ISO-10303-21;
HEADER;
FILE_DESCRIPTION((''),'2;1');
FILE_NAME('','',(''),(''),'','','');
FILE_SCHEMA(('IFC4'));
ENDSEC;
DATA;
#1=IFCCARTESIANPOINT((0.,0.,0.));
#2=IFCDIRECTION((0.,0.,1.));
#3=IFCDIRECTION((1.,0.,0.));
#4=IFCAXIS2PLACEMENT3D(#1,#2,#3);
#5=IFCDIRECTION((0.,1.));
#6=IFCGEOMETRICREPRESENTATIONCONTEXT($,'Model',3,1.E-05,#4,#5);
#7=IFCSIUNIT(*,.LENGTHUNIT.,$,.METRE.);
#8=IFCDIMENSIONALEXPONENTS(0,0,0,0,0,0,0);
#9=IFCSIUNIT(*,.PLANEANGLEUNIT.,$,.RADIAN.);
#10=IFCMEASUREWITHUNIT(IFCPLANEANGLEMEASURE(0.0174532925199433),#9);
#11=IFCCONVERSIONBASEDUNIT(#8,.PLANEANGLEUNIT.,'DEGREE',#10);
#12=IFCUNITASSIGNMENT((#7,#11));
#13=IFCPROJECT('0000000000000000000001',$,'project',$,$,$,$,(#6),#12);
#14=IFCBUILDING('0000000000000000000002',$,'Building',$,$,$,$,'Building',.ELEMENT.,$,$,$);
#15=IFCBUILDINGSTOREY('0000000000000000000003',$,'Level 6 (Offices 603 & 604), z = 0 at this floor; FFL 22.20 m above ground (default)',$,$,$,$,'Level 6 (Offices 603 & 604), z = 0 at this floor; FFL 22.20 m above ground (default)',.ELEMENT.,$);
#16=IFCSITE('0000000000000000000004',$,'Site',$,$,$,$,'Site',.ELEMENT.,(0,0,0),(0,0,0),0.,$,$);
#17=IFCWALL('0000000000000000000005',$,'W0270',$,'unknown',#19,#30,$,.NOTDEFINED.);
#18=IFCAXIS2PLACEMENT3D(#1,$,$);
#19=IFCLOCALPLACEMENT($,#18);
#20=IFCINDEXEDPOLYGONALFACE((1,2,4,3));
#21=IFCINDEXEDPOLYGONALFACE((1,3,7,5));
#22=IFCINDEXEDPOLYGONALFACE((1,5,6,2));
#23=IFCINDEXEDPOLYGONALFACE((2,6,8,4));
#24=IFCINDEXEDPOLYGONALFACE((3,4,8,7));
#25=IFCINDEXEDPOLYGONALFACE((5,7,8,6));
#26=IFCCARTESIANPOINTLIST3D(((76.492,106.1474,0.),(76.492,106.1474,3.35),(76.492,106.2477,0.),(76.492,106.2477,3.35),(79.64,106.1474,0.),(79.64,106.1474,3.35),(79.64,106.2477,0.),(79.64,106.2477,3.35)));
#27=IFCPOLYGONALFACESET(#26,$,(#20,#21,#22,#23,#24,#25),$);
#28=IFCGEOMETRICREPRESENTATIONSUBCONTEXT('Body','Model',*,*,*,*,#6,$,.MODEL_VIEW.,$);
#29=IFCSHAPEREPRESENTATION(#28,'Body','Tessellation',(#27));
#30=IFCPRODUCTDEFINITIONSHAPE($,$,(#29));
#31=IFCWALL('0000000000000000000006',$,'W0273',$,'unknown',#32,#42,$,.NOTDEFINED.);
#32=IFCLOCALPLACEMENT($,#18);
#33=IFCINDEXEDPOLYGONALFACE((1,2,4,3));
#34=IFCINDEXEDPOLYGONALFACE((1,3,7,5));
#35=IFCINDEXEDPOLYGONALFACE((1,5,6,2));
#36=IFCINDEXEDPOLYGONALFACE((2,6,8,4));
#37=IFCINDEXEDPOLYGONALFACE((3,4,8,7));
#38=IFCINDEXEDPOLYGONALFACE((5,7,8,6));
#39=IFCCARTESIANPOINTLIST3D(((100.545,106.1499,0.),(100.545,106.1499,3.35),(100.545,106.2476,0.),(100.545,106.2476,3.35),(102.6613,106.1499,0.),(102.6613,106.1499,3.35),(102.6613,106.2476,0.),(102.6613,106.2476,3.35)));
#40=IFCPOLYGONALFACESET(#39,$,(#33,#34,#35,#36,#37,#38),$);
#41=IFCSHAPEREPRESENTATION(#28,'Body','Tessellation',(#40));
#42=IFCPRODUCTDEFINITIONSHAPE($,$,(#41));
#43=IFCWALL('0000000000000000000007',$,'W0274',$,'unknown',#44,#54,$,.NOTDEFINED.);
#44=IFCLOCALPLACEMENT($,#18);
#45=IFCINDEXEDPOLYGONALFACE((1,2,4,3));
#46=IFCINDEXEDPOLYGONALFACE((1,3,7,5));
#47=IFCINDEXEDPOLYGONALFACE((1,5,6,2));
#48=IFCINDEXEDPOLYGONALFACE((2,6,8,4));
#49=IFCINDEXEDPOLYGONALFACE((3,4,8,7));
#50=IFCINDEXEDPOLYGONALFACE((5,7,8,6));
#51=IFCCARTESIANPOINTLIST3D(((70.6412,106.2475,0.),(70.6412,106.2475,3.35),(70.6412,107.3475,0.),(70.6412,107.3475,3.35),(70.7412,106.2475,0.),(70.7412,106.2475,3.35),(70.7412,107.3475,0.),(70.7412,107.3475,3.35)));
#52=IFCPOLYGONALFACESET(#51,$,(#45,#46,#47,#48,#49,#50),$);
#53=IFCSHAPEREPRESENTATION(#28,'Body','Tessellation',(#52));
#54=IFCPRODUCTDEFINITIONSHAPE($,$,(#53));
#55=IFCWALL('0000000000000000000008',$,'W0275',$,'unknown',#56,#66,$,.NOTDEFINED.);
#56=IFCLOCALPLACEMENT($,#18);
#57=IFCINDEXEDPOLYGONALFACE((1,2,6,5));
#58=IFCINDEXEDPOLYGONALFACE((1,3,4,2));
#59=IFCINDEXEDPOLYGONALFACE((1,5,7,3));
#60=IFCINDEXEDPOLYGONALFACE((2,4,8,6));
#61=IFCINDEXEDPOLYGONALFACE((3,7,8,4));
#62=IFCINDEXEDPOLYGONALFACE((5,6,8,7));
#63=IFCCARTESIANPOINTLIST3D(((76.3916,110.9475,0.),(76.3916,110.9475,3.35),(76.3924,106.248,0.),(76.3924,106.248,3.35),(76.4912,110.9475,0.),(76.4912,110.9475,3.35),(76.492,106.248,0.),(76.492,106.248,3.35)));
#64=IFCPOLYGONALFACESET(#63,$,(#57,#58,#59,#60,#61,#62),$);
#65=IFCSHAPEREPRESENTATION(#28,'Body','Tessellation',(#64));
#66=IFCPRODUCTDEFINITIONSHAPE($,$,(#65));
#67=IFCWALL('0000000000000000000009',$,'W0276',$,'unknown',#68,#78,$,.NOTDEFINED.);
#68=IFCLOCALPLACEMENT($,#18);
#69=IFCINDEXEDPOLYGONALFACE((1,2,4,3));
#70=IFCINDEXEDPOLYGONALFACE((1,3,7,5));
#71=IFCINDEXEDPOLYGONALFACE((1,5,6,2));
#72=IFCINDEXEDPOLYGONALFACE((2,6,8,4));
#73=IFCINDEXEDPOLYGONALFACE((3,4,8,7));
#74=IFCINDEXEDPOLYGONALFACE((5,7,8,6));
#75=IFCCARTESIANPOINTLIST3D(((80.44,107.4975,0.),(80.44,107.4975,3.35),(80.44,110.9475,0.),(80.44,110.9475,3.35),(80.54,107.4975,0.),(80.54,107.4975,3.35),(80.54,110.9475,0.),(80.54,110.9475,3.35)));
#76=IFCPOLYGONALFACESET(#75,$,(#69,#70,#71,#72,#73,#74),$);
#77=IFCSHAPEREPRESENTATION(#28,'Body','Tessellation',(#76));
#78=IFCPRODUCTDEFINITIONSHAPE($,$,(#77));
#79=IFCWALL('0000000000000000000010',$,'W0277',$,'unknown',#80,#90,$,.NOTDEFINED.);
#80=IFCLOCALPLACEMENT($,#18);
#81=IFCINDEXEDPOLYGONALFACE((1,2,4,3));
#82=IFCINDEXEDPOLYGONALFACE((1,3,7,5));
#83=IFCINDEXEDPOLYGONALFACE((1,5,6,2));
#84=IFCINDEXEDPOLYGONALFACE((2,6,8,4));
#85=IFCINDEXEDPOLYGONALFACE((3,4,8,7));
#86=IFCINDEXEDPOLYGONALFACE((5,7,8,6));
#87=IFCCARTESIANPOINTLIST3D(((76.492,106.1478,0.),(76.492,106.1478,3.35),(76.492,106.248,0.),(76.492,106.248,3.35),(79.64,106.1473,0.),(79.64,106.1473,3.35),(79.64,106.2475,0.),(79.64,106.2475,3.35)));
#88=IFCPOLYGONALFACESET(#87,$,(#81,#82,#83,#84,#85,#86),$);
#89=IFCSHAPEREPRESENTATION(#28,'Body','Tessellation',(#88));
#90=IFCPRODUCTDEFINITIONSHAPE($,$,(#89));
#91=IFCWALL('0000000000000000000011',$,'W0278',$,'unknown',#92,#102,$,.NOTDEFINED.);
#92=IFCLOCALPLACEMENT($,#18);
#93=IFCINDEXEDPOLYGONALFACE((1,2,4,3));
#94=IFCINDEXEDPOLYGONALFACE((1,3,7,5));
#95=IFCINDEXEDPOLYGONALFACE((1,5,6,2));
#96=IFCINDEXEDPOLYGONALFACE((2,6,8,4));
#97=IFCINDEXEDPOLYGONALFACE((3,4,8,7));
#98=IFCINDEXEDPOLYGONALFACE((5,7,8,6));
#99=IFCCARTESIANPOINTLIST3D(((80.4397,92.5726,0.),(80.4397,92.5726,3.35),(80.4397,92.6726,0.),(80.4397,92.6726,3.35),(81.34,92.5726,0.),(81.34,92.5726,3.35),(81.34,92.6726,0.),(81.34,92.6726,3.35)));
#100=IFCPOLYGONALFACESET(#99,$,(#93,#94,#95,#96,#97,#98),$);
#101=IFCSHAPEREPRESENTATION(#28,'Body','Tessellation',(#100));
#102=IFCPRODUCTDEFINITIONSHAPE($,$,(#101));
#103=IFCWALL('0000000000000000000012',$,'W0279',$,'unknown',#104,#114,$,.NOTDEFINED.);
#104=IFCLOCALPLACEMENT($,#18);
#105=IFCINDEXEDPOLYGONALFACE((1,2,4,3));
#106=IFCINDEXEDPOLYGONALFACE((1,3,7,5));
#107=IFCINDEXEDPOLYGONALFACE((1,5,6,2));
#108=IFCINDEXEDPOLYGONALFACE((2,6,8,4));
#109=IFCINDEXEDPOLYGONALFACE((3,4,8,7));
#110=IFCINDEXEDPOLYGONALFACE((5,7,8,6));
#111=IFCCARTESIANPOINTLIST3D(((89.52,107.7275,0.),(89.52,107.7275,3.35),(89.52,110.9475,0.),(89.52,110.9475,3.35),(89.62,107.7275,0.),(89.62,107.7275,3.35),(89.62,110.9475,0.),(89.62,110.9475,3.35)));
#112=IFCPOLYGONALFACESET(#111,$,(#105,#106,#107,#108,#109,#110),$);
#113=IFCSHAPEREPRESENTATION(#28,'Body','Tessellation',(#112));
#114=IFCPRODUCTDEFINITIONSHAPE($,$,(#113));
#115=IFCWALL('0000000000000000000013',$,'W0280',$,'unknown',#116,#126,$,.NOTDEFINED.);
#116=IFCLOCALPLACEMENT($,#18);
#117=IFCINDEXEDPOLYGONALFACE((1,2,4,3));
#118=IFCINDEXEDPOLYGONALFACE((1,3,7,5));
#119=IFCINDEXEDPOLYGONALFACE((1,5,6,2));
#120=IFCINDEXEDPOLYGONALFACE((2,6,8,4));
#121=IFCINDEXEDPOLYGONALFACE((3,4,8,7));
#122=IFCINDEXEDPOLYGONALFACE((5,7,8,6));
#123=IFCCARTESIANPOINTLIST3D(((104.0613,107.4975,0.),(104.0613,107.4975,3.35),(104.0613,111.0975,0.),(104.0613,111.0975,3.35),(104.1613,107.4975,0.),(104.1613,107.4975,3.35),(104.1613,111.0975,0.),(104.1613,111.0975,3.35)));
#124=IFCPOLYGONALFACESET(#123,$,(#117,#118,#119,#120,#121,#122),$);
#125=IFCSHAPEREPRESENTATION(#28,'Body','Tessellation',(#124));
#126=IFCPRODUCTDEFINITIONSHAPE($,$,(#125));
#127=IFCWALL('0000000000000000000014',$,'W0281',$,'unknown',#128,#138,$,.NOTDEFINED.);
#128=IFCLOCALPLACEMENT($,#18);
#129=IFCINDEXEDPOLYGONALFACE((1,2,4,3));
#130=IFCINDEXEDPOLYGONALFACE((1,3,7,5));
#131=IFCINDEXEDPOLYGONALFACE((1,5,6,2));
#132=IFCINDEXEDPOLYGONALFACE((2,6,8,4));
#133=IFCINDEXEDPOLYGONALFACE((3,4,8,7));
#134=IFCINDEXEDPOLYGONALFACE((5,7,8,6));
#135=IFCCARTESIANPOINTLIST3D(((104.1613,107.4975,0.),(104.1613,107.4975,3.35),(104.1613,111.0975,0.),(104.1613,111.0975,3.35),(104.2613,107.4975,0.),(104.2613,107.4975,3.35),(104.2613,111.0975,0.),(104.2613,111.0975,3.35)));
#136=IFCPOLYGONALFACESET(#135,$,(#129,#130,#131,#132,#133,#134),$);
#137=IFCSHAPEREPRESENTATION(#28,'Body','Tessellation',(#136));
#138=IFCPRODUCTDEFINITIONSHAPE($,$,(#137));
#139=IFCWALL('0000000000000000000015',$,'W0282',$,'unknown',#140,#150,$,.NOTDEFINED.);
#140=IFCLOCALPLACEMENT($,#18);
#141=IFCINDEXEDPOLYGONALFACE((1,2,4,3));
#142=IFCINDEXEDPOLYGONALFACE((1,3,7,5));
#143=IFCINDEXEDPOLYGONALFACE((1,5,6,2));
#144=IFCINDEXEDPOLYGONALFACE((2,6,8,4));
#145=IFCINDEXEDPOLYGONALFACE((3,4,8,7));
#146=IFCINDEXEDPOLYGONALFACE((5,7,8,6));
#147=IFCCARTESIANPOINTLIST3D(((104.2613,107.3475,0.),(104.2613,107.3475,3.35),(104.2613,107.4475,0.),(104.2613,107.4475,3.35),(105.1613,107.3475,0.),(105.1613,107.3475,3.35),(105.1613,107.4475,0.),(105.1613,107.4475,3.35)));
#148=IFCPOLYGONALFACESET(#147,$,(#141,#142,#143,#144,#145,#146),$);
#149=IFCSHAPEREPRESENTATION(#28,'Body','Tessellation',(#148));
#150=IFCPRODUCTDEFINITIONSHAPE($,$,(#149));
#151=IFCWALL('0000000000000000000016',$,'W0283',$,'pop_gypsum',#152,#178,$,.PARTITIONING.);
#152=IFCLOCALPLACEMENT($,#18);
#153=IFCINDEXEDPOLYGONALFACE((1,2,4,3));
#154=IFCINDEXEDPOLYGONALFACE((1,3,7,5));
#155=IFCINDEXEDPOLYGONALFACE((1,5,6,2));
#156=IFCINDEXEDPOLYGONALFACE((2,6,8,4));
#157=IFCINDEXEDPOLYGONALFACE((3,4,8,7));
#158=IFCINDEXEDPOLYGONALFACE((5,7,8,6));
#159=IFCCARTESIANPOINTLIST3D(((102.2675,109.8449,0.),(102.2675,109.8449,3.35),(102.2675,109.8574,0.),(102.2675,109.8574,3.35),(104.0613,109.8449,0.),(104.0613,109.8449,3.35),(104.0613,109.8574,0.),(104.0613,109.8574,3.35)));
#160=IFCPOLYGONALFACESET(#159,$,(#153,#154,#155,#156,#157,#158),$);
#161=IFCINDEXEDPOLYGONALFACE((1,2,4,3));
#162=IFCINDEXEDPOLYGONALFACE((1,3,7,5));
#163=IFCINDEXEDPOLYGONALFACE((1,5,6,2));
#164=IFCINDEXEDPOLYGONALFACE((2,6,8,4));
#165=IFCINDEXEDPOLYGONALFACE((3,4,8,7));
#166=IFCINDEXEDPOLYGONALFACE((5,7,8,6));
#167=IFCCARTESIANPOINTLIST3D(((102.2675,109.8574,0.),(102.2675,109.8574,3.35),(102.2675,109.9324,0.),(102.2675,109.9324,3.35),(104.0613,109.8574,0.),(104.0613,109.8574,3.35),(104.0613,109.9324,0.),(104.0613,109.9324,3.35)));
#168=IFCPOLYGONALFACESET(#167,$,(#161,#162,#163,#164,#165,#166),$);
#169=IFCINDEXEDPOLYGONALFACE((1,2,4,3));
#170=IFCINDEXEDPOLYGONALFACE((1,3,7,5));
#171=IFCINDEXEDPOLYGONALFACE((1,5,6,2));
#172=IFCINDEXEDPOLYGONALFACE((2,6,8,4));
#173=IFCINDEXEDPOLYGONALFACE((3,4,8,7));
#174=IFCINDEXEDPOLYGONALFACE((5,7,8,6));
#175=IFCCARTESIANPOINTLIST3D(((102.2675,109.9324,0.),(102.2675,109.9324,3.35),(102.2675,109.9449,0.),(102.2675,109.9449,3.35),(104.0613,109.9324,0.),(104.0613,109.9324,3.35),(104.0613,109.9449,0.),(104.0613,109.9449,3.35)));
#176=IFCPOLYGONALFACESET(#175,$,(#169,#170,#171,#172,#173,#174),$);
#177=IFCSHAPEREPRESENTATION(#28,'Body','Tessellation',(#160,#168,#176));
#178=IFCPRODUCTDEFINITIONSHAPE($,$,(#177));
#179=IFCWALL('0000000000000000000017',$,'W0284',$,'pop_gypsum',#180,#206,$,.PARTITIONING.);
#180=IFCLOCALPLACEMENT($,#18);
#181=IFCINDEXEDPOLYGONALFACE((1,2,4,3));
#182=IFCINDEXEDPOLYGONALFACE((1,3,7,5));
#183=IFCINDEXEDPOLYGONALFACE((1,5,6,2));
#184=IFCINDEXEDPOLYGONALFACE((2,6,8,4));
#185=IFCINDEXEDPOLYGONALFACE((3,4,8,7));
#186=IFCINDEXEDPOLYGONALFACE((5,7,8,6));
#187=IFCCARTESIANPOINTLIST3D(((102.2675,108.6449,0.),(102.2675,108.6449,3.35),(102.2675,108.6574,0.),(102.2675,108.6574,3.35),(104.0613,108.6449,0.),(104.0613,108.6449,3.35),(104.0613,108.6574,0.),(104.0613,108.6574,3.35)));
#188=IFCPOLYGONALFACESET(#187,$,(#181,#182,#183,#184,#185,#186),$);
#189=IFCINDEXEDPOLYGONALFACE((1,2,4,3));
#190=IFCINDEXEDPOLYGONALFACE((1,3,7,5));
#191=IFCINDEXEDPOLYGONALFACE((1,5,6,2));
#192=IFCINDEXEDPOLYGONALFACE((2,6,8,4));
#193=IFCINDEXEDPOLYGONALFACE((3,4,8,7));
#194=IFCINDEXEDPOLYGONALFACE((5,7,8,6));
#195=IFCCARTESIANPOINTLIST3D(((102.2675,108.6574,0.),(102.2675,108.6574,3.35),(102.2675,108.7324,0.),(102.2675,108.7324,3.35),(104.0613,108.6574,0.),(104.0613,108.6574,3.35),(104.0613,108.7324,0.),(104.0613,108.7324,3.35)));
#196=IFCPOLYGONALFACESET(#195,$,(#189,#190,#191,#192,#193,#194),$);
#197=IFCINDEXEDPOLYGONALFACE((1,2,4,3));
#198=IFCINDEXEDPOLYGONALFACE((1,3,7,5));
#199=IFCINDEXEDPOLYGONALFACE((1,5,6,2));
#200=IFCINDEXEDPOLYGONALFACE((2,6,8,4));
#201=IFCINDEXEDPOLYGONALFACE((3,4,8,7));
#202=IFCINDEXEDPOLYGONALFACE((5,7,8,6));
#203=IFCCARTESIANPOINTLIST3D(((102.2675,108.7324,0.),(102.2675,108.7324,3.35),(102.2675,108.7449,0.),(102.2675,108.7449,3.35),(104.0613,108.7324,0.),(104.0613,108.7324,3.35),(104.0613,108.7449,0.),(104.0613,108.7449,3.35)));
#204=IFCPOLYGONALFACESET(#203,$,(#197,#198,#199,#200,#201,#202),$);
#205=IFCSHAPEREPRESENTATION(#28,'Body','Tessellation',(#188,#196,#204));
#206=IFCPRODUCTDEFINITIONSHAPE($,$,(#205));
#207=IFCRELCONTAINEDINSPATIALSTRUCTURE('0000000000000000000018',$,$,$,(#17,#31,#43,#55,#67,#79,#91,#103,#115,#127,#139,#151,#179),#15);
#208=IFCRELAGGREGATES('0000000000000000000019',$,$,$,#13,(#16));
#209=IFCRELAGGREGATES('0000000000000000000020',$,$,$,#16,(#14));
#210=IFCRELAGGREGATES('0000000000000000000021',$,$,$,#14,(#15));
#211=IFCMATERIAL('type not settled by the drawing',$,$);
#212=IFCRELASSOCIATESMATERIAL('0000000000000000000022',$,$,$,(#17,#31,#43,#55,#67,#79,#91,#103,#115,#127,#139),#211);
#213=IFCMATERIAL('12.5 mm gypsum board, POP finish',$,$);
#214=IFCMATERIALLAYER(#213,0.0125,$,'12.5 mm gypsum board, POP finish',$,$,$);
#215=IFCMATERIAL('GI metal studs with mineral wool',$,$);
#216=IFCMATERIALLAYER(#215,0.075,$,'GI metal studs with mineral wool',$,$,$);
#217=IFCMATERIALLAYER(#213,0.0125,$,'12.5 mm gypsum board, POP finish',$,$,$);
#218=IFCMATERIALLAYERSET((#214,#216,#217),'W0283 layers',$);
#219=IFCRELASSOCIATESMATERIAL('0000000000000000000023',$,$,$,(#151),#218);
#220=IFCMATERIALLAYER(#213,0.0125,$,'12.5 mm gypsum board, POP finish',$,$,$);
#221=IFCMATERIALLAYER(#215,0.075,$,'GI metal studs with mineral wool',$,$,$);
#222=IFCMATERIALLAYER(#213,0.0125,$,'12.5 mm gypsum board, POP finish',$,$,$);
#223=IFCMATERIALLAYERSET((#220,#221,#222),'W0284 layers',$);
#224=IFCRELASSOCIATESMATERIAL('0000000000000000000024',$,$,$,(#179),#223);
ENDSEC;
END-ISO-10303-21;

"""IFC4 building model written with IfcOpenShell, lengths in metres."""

from ifc_helpers import new_model, entity, si_unit, converted_unit, direction, frame, frame_2d, origin_with_axes, place, context, subcontext, project, spatial, rectangle, extrude, material, layer, layer_set, layer_usage, element, save


model = new_model("IFC4")

# Units and contexts
model_context = context("Model", 3, precision=1e-05, world=origin_with_axes(), true_north=direction((0.0, 1.0)))
body_context = subcontext(model_context, "Body", "Model", "MODEL_VIEW")
ifc_project = project(units=[si_unit("LENGTHUNIT", "METRE"), converted_unit("PLANEANGLEUNIT", "DEGREE", entity("IfcPlaneAngleMeasure", 0.0174532925199433), si_unit("PLANEANGLEUNIT", "RADIAN"), dimensions=[0, 0, 0, 0, 0, 0, 0])], contexts=[model_context])

# Site, building, storey
site = spatial("IfcSite", under=ifc_project, Name="Site", LongName="Site", CompositionType="ELEMENT", RefLatitude=(0, 0, 0), RefLongitude=(0, 0, 0), RefElevation=0.0)
building = spatial("IfcBuilding", under=site, Name="Building", LongName="Building", CompositionType="ELEMENT")
storey = spatial("IfcBuildingStorey", under=building, Name="Level 6 (Offices 603 & 604), z = 0 at this floor; FFL 22.20 m above ground (default)", LongName="Level 6 (Offices 603 & 604), z = 0 at this floor; FFL 22.20 m above ground (default)", CompositionType="ELEMENT")

# Walls
ifc_material_1 = material(Name="type not settled by the drawing")
placement = place(None, origin_with_axes())
element("IfcWall", 1, at=placement, inside=storey, material=ifc_material_1, Name="W0270", ObjectType="unknown", PredefinedType="NOTDEFINED", context=body_context, shape_type="SweptSolid", body=[
    extrude(rectangle(XDim=3.148, YDim=0.1003, at=frame_2d((0.0, 0.0), x_axis=(1.0, 0.0))), frame((78.066, 106.1976, 0.0), z_axis=(0.0, 0.0, 1.0), x_axis=(1.0, 0.0, 0.0)), (0.0, 0.0, 1.0), 3.35),
])
element("IfcWall", 2, at=placement, inside=storey, material=ifc_material_1, Name="W0273", ObjectType="unknown", PredefinedType="NOTDEFINED", context=body_context, shape_type="SweptSolid", body=[
    extrude(rectangle(XDim=2.1163, YDim=0.0977, at=frame_2d((0.0, 0.0), x_axis=(1.0, 0.0))), frame((101.6031, 106.1987, 0.0), z_axis=(0.0, 0.0, 1.0), x_axis=(1.0, 0.0, 0.0)), (0.0, 0.0, 1.0), 3.35),
])
element("IfcWall", 3, at=placement, inside=storey, material=ifc_material_1, Name="W0274", ObjectType="unknown", PredefinedType="NOTDEFINED", context=body_context, shape_type="SweptSolid", body=[
    extrude(rectangle(XDim=1.1, YDim=0.1, at=frame_2d((0.0, 0.0), x_axis=(0.0, 1.0))), frame((70.6912, 106.7975, 0.0), z_axis=(0.0, 0.0, 1.0), x_axis=(1.0, 0.0, 0.0)), (0.0, 0.0, 1.0), 3.35),
])
element("IfcWall", 4, at=placement, inside=storey, material=ifc_material_1, Name="W0275", ObjectType="unknown", PredefinedType="NOTDEFINED", context=body_context, shape_type="SweptSolid", body=[
    extrude(rectangle(XDim=4.6995, YDim=0.0996, at=frame_2d((0.0, 0.0), x_axis=(0.00017, -1.0))), frame((76.4418, 108.5978, 0.0), z_axis=(0.0, 0.0, 1.0), x_axis=(1.0, 0.0, 0.0)), (0.0, 0.0, 1.0), 3.35),
])
element("IfcWall", 5, at=placement, inside=storey, material=ifc_material_1, Name="W0276", ObjectType="unknown", PredefinedType="NOTDEFINED", context=body_context, shape_type="SweptSolid", body=[
    extrude(rectangle(XDim=3.45, YDim=0.1, at=frame_2d((0.0, 0.0), x_axis=(0.0, 1.0))), frame((80.49, 109.2225, 0.0), z_axis=(0.0, 0.0, 1.0), x_axis=(1.0, 0.0, 0.0)), (0.0, 0.0, 1.0), 3.35),
])
element("IfcWall", 6, at=placement, inside=storey, material=ifc_material_1, Name="W0277", ObjectType="unknown", PredefinedType="NOTDEFINED", context=body_context, shape_type="SweptSolid", body=[
    extrude(rectangle(XDim=3.148, YDim=0.1003, at=frame_2d((0.0, 0.0), x_axis=(1.0, -0.000159))), frame((78.066, 106.1976, 0.0), z_axis=(0.0, 0.0, 1.0), x_axis=(1.0, 0.0, 0.0)), (0.0, 0.0, 1.0), 3.35),
])
element("IfcWall", 7, at=placement, inside=storey, material=ifc_material_1, Name="W0278", ObjectType="unknown", PredefinedType="NOTDEFINED", context=body_context, shape_type="SweptSolid", body=[
    extrude(rectangle(XDim=0.9003, YDim=0.1, at=frame_2d((0.0, 0.0), x_axis=(1.0, 0.0))), frame((80.8898, 92.6226, 0.0), z_axis=(0.0, 0.0, 1.0), x_axis=(1.0, 0.0, 0.0)), (0.0, 0.0, 1.0), 3.35),
])
element("IfcWall", 8, at=placement, inside=storey, material=ifc_material_1, Name="W0279", ObjectType="unknown", PredefinedType="NOTDEFINED", context=body_context, shape_type="SweptSolid", body=[
    extrude(rectangle(XDim=3.22, YDim=0.1, at=frame_2d((0.0, 0.0), x_axis=(0.0, 1.0))), frame((89.57, 109.3375, 0.0), z_axis=(0.0, 0.0, 1.0), x_axis=(1.0, 0.0, 0.0)), (0.0, 0.0, 1.0), 3.35),
])
element("IfcWall", 9, at=placement, inside=storey, material=ifc_material_1, Name="W0280", ObjectType="unknown", PredefinedType="NOTDEFINED", context=body_context, shape_type="SweptSolid", body=[
    extrude(rectangle(XDim=3.6, YDim=0.1, at=frame_2d((0.0, 0.0), x_axis=(0.0, 1.0))), frame((104.1113, 109.2975, 0.0), z_axis=(0.0, 0.0, 1.0), x_axis=(1.0, 0.0, 0.0)), (0.0, 0.0, 1.0), 3.35),
])
element("IfcWall", 10, at=placement, inside=storey, material=ifc_material_1, Name="W0281", ObjectType="unknown", PredefinedType="NOTDEFINED", context=body_context, shape_type="SweptSolid", body=[
    extrude(rectangle(XDim=3.6, YDim=0.1, at=frame_2d((0.0, 0.0), x_axis=(0.0, 1.0))), frame((104.2113, 109.2975, 0.0), z_axis=(0.0, 0.0, 1.0), x_axis=(1.0, 0.0, 0.0)), (0.0, 0.0, 1.0), 3.35),
])
element("IfcWall", 11, at=placement, inside=storey, material=ifc_material_1, Name="W0282", ObjectType="unknown", PredefinedType="NOTDEFINED", context=body_context, shape_type="SweptSolid", body=[
    extrude(rectangle(XDim=0.9, YDim=0.1, at=frame_2d((0.0, 0.0), x_axis=(1.0, 0.0))), frame((104.7113, 107.3975, 0.0), z_axis=(0.0, 0.0, 1.0), x_axis=(1.0, 0.0, 0.0)), (0.0, 0.0, 1.0), 3.35),
])
ifc_material_2 = material(Name="12.5 mm gypsum board, POP finish")
ifc_layer_1 = layer(ifc_material_2, 0.0125, Name="12.5 mm gypsum board, POP finish")
ifc_material_3 = material(Name="GI metal studs with mineral wool")
ifc_layer_2 = layer(ifc_material_3, 0.075, Name="GI metal studs with mineral wool")
ifc_layer_3 = layer(ifc_material_2, 0.0125, Name="12.5 mm gypsum board, POP finish")
ifc_layer_set_1 = layer_set([ifc_layer_1, ifc_layer_2, ifc_layer_3], Name="W0283 layers")
ifc_layer_usage_1 = layer_usage(ifc_layer_set_1, "AXIS2", "POSITIVE", -0.05)
element("IfcWall", 12, at=placement, inside=storey, material=ifc_layer_usage_1, Name="W0283", ObjectType="pop_gypsum", PredefinedType="PARTITIONING", context=body_context, shape_type="SweptSolid", body=[
    extrude(rectangle(XDim=1.7938, YDim=0.0125, at=frame_2d((0.0, 0.0), x_axis=(1.0, 0.0))), frame((103.1644, 109.8512, 0.0), z_axis=(0.0, 0.0, 1.0), x_axis=(1.0, 0.0, 0.0)), (0.0, 0.0, 1.0), 3.35),
    extrude(rectangle(XDim=1.7938, YDim=0.075, at=frame_2d((0.0, 0.0437), x_axis=(1.0, 0.0))), frame((103.1644, 109.8512, 0.0), z_axis=(0.0, 0.0, 1.0), x_axis=(1.0, 0.0, 0.0)), (0.0, 0.0, 1.0), 3.35),
    extrude(rectangle(XDim=1.7938, YDim=0.0125, at=frame_2d((0.0, 0.0875), x_axis=(1.0, 0.0))), frame((103.1644, 109.8512, 0.0), z_axis=(0.0, 0.0, 1.0), x_axis=(1.0, 0.0, 0.0)), (0.0, 0.0, 1.0), 3.35),
])
ifc_layer_4 = layer(ifc_material_2, 0.0125, Name="12.5 mm gypsum board, POP finish")
ifc_layer_5 = layer(ifc_material_3, 0.075, Name="GI metal studs with mineral wool")
ifc_layer_6 = layer(ifc_material_2, 0.0125, Name="12.5 mm gypsum board, POP finish")
ifc_layer_set_2 = layer_set([ifc_layer_4, ifc_layer_5, ifc_layer_6], Name="W0284 layers")
ifc_layer_usage_2 = layer_usage(ifc_layer_set_2, "AXIS2", "POSITIVE", -0.05)
element("IfcWall", 13, at=placement, inside=storey, material=ifc_layer_usage_2, Name="W0284", ObjectType="pop_gypsum", PredefinedType="PARTITIONING", context=body_context, shape_type="SweptSolid", body=[
    extrude(rectangle(XDim=1.7938, YDim=0.0125, at=frame_2d((0.0, 0.0), x_axis=(1.0, 0.0))), frame((103.1644, 108.6512, 0.0), z_axis=(0.0, 0.0, 1.0), x_axis=(1.0, 0.0, 0.0)), (0.0, 0.0, 1.0), 3.35),
    extrude(rectangle(XDim=1.7938, YDim=0.075, at=frame_2d((0.0, 0.0437), x_axis=(1.0, 0.0))), frame((103.1644, 108.6512, 0.0), z_axis=(0.0, 0.0, 1.0), x_axis=(1.0, 0.0, 0.0)), (0.0, 0.0, 1.0), 3.35),
    extrude(rectangle(XDim=1.7938, YDim=0.0125, at=frame_2d((0.0, 0.0875), x_axis=(1.0, 0.0))), frame((103.1644, 108.6512, 0.0), z_axis=(0.0, 0.0, 1.0), x_axis=(1.0, 0.0, 0.0)), (0.0, 0.0, 1.0), 3.35),
])

save(model, "model.ifc")
